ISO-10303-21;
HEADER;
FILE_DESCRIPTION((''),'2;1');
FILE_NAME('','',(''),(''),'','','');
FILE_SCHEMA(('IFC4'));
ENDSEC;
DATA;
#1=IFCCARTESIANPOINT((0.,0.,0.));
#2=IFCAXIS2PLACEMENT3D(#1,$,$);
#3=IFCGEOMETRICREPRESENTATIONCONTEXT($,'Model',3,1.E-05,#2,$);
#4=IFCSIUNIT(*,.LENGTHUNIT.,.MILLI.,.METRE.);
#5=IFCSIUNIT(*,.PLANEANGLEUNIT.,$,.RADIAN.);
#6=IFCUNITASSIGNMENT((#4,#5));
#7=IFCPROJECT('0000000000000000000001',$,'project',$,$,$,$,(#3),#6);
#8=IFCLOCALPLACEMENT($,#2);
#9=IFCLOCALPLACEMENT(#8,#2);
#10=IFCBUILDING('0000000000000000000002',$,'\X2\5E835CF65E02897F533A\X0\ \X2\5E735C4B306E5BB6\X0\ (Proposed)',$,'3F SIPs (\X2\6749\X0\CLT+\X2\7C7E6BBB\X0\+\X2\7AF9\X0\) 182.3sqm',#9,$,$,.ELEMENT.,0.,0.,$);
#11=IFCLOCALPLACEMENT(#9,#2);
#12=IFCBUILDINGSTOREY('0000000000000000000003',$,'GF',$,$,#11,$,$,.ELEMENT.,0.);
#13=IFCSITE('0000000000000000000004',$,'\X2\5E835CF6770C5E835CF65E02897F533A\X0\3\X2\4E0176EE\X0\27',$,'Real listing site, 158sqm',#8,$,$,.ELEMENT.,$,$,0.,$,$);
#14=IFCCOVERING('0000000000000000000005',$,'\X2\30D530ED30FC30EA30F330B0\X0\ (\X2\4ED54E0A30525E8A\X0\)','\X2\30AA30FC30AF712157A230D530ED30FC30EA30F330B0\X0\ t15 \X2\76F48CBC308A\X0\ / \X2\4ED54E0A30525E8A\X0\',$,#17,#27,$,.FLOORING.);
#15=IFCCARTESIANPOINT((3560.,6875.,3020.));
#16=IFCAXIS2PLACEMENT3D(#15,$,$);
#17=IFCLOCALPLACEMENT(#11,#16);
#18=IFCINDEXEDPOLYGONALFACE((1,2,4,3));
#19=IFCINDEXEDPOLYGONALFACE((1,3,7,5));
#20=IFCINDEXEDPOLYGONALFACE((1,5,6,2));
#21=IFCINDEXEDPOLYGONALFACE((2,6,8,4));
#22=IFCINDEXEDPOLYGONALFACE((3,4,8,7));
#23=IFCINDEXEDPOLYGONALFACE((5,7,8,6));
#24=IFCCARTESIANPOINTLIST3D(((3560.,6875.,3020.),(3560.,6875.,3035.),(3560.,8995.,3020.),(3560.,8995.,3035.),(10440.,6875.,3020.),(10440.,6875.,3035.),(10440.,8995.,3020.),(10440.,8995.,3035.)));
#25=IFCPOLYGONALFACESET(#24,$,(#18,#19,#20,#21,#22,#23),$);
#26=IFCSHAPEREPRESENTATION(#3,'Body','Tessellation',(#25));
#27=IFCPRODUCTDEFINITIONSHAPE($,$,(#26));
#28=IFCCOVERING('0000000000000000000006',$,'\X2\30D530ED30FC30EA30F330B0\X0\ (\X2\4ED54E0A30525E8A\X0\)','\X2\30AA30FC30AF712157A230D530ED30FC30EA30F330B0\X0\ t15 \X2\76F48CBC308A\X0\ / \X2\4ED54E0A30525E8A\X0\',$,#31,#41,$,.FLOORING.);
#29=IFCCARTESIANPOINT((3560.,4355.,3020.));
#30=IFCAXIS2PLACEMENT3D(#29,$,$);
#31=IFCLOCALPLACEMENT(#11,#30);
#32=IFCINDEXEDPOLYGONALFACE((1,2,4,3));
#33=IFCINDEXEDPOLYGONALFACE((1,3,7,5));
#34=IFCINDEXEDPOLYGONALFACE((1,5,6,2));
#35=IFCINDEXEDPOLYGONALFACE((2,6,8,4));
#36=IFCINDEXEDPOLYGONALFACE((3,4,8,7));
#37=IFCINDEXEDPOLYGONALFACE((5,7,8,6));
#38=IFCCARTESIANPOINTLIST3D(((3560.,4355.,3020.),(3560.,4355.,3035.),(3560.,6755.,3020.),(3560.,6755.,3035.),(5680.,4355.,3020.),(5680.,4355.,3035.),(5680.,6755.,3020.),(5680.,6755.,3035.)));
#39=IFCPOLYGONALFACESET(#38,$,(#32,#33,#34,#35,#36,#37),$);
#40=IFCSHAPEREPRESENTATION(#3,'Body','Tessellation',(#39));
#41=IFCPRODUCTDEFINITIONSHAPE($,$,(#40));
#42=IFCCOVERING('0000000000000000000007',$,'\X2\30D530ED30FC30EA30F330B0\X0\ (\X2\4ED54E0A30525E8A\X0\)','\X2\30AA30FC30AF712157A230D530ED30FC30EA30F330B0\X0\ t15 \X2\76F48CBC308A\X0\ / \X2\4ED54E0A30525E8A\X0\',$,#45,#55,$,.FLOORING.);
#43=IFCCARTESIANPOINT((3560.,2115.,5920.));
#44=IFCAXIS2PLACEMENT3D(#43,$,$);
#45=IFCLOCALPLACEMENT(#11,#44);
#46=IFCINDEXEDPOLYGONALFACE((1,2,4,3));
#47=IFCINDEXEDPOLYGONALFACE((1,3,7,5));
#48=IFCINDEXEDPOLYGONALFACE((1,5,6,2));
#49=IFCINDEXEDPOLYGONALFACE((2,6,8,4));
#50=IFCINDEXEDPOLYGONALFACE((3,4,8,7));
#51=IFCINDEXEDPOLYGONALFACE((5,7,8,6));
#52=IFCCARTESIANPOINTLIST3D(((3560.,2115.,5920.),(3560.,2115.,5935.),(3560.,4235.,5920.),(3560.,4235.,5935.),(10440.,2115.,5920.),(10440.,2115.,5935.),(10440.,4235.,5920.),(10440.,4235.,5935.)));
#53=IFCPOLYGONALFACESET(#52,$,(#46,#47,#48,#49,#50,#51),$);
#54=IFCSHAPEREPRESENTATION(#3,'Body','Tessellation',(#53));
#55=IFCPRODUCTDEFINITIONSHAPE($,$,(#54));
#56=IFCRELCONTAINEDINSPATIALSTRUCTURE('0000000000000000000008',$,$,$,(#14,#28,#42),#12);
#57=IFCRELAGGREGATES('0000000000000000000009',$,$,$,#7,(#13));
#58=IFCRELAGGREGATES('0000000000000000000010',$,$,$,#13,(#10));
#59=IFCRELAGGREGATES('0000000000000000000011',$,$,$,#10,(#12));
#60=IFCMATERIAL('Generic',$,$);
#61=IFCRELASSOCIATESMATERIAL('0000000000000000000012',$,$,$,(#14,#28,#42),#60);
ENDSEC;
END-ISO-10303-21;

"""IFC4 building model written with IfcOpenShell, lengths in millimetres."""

from ifc_helpers import new_model, si_unit, frame, frame_2d, origin, place, context, project, spatial, rectangle, extrude, material, element, save


model = new_model("IFC4")

# Units and contexts
model_context = context("Model", 3, precision=1e-05, world=origin())
ifc_project = project(units=[si_unit("LENGTHUNIT", "METRE", prefix="MILLI"), si_unit("PLANEANGLEUNIT", "RADIAN")], contexts=[model_context])

# Site, building, storey
site_placement = place(None, origin())
site = spatial("IfcSite", under=ifc_project, at=site_placement, Name="広島県広島市西区3丁目27", ObjectType="Real listing site, 158sqm", CompositionType="ELEMENT", RefElevation=0.0)
building_placement = place(site_placement, origin())
building = spatial("IfcBuilding", under=site, at=building_placement, Name="広島市西区 平屋の家 (Proposed)", ObjectType="3F SIPs (杉CLT+籾殻+竹) 182.3sqm", CompositionType="ELEMENT", ElevationOfRefHeight=0.0, ElevationOfTerrain=0.0)
storey_placement = place(building_placement, origin())
storey = spatial("IfcBuildingStorey", under=building, at=storey_placement, Name="GF", CompositionType="ELEMENT", Elevation=0.0)

# Shared definitions
ifc_material_1 = material(Name="Generic")

# Coverings
covering_1_placement = place(storey_placement, frame((3560.0, 6875.0, 3020.0)))
element("IfcCovering", 1, at=covering_1_placement, inside=storey, material=ifc_material_1, Name="フローリング (仕上げ床)", Description="オーク無垢フローリング t15 直貼り / 仕上げ床", PredefinedType="FLOORING", context=model_context, shape_type="SweptSolid", body=[
    extrude(rectangle(XDim=6880.0, YDim=2120.0, at=frame_2d((3440.0, 1060.0))), frame((3560.0, 6875.0, 3020.0)), (0.0, 0.0, 1.0), 15.0),
])
covering_2_placement = place(storey_placement, frame((3560.0, 4355.0, 3020.0)))
element("IfcCovering", 2, at=covering_2_placement, inside=storey, material=ifc_material_1, Name="フローリング (仕上げ床)", Description="オーク無垢フローリング t15 直貼り / 仕上げ床", PredefinedType="FLOORING", context=model_context, shape_type="SweptSolid", body=[
    extrude(rectangle(XDim=2120.0, YDim=2400.0, at=frame_2d((1060.0, 1200.0))), frame((3560.0, 4355.0, 3020.0)), (0.0, 0.0, 1.0), 15.0),
])
covering_3_placement = place(storey_placement, frame((3560.0, 2115.0, 5920.0)))
element("IfcCovering", 3, at=covering_3_placement, inside=storey, material=ifc_material_1, Name="フローリング (仕上げ床)", Description="オーク無垢フローリング t15 直貼り / 仕上げ床", PredefinedType="FLOORING", context=model_context, shape_type="SweptSolid", body=[
    extrude(rectangle(XDim=6880.0, YDim=2120.0, at=frame_2d((3440.0, 1060.0))), frame((3560.0, 2115.0, 5920.0)), (0.0, 0.0, 1.0), 15.0),
])

save(model, "model.ifc")
